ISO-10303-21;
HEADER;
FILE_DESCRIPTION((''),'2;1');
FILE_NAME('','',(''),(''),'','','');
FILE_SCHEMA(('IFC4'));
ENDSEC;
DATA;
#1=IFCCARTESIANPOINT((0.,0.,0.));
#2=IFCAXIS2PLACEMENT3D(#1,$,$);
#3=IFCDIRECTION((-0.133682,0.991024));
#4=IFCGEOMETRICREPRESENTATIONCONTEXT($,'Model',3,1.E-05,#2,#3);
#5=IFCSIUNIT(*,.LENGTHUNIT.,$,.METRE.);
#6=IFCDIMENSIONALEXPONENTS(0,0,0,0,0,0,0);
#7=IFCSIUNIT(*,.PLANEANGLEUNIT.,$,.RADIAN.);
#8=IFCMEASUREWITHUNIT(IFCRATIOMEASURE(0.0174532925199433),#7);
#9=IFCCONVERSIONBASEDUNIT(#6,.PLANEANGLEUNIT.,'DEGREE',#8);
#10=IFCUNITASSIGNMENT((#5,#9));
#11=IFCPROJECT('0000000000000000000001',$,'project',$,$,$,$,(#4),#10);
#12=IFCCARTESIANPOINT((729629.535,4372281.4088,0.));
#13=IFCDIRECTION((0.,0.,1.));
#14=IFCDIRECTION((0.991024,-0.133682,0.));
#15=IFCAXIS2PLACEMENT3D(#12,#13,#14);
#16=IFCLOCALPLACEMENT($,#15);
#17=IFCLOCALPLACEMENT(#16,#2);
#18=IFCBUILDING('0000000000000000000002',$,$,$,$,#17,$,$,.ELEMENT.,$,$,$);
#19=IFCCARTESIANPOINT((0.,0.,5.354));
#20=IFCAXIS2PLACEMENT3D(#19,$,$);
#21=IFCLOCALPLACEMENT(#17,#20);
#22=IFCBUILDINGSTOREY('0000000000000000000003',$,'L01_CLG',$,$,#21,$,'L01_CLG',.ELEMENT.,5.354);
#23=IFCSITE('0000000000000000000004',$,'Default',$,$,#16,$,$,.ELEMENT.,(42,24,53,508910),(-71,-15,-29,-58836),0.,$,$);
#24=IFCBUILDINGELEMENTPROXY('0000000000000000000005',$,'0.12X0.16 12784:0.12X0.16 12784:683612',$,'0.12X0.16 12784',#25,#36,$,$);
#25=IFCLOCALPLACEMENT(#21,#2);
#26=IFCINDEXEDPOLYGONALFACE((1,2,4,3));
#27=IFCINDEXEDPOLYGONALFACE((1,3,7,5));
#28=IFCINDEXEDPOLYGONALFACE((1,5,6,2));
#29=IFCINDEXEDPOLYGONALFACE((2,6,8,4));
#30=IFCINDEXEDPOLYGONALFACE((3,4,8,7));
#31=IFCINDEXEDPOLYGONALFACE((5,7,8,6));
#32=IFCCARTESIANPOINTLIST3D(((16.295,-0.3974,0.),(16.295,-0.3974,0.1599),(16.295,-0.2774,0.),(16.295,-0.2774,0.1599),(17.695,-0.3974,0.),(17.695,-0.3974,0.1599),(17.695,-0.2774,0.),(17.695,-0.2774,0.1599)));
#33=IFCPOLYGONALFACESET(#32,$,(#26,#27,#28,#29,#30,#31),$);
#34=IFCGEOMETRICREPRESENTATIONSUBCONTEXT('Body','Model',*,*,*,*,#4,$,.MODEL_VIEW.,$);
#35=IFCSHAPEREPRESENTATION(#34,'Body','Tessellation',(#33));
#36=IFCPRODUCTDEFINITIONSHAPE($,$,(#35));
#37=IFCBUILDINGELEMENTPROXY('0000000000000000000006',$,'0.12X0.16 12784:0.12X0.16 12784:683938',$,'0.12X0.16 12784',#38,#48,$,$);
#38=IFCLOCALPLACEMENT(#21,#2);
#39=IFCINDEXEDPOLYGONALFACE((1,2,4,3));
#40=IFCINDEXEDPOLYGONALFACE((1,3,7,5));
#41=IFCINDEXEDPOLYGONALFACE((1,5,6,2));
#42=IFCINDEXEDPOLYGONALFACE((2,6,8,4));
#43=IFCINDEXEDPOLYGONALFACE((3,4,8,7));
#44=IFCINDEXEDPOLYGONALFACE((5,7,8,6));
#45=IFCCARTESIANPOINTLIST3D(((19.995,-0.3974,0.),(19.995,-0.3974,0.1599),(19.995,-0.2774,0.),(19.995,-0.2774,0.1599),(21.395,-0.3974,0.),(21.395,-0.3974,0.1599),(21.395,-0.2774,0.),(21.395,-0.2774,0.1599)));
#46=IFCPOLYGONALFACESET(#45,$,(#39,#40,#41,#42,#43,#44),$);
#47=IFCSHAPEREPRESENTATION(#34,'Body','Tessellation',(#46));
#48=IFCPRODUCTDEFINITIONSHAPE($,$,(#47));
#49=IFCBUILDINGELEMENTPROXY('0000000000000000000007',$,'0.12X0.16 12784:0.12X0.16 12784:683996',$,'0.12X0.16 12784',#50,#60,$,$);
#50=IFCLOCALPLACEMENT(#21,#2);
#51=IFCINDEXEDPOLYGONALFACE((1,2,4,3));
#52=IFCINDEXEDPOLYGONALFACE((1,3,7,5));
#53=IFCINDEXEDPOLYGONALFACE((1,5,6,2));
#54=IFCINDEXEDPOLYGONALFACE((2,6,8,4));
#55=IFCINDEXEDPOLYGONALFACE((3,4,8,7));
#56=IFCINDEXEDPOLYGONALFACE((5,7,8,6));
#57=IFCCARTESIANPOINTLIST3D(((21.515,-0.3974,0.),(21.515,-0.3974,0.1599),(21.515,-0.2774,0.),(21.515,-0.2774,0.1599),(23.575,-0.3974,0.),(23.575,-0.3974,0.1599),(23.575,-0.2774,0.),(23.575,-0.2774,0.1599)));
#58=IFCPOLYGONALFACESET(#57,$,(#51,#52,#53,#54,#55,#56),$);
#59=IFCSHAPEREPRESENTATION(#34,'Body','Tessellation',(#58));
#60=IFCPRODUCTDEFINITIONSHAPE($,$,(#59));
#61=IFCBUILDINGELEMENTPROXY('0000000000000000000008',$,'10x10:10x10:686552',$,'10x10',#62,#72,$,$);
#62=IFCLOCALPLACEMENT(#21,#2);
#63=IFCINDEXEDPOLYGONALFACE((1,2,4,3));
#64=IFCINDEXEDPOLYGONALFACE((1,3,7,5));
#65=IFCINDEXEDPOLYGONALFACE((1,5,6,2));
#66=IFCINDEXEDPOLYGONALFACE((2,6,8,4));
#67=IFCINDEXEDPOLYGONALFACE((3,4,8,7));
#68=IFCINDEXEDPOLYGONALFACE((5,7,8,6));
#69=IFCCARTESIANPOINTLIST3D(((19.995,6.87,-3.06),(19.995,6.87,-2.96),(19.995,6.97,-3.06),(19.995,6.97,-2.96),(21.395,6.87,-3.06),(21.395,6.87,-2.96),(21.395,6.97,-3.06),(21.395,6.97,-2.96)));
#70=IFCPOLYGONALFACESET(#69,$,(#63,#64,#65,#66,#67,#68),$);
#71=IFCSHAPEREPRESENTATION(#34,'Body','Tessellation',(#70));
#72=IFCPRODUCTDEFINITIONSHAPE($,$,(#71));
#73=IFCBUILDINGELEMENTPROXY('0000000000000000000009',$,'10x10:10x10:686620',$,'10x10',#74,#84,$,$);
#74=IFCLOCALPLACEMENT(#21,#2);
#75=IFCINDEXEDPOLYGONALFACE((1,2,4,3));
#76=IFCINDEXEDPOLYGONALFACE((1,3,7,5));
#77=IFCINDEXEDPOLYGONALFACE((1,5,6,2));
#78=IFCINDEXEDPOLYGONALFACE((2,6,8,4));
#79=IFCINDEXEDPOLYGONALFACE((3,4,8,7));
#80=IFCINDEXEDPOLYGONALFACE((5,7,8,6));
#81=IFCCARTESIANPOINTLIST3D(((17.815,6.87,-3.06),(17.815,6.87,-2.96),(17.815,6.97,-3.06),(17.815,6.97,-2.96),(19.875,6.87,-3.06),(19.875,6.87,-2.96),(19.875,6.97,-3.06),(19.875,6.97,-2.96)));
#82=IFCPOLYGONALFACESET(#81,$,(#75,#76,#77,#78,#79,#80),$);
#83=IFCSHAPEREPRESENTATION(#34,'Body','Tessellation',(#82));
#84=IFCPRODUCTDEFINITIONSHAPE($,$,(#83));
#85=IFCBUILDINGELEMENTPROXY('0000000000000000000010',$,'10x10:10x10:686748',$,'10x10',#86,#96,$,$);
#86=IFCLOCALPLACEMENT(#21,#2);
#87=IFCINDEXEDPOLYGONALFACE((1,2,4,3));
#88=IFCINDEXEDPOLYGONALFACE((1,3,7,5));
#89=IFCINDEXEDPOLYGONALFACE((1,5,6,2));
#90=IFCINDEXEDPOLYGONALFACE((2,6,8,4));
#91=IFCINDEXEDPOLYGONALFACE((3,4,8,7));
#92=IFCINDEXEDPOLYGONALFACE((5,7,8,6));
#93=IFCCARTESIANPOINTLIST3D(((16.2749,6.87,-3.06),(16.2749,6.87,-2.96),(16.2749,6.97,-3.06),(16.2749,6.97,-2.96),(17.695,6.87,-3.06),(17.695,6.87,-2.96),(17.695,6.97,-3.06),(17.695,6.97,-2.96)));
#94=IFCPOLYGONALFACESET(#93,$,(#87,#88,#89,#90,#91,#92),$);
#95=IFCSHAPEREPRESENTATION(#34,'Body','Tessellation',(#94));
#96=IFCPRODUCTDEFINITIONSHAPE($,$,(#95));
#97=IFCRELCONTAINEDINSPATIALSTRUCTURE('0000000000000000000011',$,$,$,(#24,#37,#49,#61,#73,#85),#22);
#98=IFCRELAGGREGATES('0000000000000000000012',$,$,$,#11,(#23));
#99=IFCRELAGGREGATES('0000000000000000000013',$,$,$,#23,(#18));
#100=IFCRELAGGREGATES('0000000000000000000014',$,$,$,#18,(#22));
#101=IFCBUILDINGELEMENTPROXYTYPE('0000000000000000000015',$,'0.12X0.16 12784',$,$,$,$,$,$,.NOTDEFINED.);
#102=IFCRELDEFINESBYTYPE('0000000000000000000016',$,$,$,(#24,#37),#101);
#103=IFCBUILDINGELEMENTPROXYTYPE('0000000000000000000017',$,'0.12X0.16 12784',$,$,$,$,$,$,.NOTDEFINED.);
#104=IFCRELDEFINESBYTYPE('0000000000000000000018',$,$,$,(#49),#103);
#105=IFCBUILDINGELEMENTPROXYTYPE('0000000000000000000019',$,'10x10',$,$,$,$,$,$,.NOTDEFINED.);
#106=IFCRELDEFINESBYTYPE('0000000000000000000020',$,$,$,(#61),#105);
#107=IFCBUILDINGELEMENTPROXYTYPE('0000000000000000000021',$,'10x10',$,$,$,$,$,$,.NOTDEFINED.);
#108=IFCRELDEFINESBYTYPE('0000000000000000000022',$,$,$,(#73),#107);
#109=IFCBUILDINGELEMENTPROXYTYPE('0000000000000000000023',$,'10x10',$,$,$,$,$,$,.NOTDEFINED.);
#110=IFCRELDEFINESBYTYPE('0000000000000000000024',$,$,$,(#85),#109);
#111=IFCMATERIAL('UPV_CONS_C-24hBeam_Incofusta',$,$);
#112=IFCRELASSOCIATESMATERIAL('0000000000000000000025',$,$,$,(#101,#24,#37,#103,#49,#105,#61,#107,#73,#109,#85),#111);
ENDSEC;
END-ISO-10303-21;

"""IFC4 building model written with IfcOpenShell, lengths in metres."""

from ifc_helpers import new_model, entity, si_unit, converted_unit, direction, frame, frame_2d, origin, place, context, subcontext, project, spatial, rectangle, extrude, source, transform, mapped, material, type_object, type_shapes, element, save


model = new_model("IFC4")

# Units and contexts
model_context = context("Model", 3, precision=1e-05, world=origin(), true_north=direction((-0.133682, 0.991024)))
body_context = subcontext(model_context, "Body", "Model", "MODEL_VIEW")
ifc_project = project(units=[si_unit("LENGTHUNIT", "METRE"), converted_unit("PLANEANGLEUNIT", "DEGREE", entity("IfcRatioMeasure", 0.0174532925199433), si_unit("PLANEANGLEUNIT", "RADIAN"), dimensions=[0, 0, 0, 0, 0, 0, 0])], contexts=[model_context])

# Site, building, storey
site_placement = place(None, frame((729629.535, 4372281.4088, 0.0), z_axis=(0.0, 0.0, 1.0), x_axis=(0.991024, -0.133682, 0.0)))
site = spatial("IfcSite", under=ifc_project, at=site_placement, Name="Default", CompositionType="ELEMENT", RefLatitude=(42, 24, 53, 508910), RefLongitude=(-71, -15, -29, -58836), RefElevation=0.0)
building_placement = place(site_placement, origin())
building = spatial("IfcBuilding", under=site, at=building_placement, CompositionType="ELEMENT")
storey_placement = place(building_placement, frame((0.0, 0.0, 5.354)))
storey = spatial("IfcBuildingStorey", under=building, at=storey_placement, Name="L01_CLG", LongName="L01_CLG", CompositionType="ELEMENT", Elevation=5.354)

# Building element proxies
ifc_material_1 = material(Name="UPV_CONS_C-24hBeam_Incofusta")
building_element_proxy_type_1 = type_object("IfcBuildingElementProxyType", Name="0.12X0.16 12784", material=ifc_material_1)
shared_shape_1 = source(origin(), body_context, "Body", "SweptSolid", [
    extrude(rectangle(XDim=0.12, YDim=1.4, at=frame_2d((0.0, 0.0), x_axis=(1.0, 0.0))), frame((0.7, 0.06, 0.0), z_axis=(0.0, 0.0, 1.0), x_axis=(0.0, -1.0, 0.0)), (0.0, 0.0, 1.0), 0.1599),
])
type_shapes(building_element_proxy_type_1, [shared_shape_1])
for number, where, name in (
    (1, (16.295, -0.3974, 0.0), "0.12X0.16 12784:0.12X0.16 12784:683612"),
    (2, (19.995, -0.3974, 0.0), "0.12X0.16 12784:0.12X0.16 12784:683938"),
):
    element("IfcBuildingElementProxy", number, at=place(storey_placement, frame(where)), inside=storey, type_object=building_element_proxy_type_1, material=ifc_material_1, Name=name, ObjectType="0.12X0.16 12784", context=body_context, shape_type="MappedRepresentation", body=[
        mapped(shared_shape_1, transform((0.0, 0.0, 0.0), scale=1.0)),
    ])
building_element_proxy_type_2 = type_object("IfcBuildingElementProxyType", Name="0.12X0.16 12784", material=ifc_material_1)
shared_shape_2 = source(origin(), body_context, "Body", "SweptSolid", [
    extrude(rectangle(XDim=0.12, YDim=2.06, at=frame_2d((0.0, 0.0), x_axis=(1.0, 0.0))), frame((1.03, 0.06, 0.0), z_axis=(0.0, 0.0, 1.0), x_axis=(0.0, -1.0, 0.0)), (0.0, 0.0, 1.0), 0.1599),
])
type_shapes(building_element_proxy_type_2, [shared_shape_2])
proxy_1_placement = place(storey_placement, frame((21.515, -0.3974, 0.0)))
element("IfcBuildingElementProxy", 3, at=proxy_1_placement, inside=storey, type_object=building_element_proxy_type_2, material=ifc_material_1, Name="0.12X0.16 12784:0.12X0.16 12784:683996", ObjectType="0.12X0.16 12784", context=body_context, shape_type="MappedRepresentation", body=[
    mapped(shared_shape_2, transform((0.0, 0.0, 0.0), scale=1.0)),
])
building_element_proxy_type_3 = type_object("IfcBuildingElementProxyType", Name="10x10", material=ifc_material_1)
shared_shape_3 = source(origin(), body_context, "Body", "SweptSolid", [
    extrude(rectangle(XDim=0.1, YDim=1.4, at=frame_2d((0.0, 0.0), x_axis=(1.0, 0.0))), frame((0.7, 0.05, 0.0), z_axis=(0.0, 0.0, 1.0), x_axis=(0.0, -1.0, 0.0)), (0.0, 0.0, 1.0), 0.1),
])
type_shapes(building_element_proxy_type_3, [shared_shape_3])
proxy_2_placement = place(storey_placement, frame((19.995, 6.87, -3.06)))
element("IfcBuildingElementProxy", 4, at=proxy_2_placement, inside=storey, type_object=building_element_proxy_type_3, material=ifc_material_1, Name="10x10:10x10:686552", ObjectType="10x10", context=body_context, shape_type="MappedRepresentation", body=[
    mapped(shared_shape_3, transform((0.0, 0.0, 0.0), scale=1.0)),
])
building_element_proxy_type_4 = type_object("IfcBuildingElementProxyType", Name="10x10", material=ifc_material_1)
shared_shape_4 = source(origin(), body_context, "Body", "SweptSolid", [
    extrude(rectangle(XDim=0.1, YDim=2.06, at=frame_2d((0.0, 0.0), x_axis=(1.0, 0.0))), frame((1.03, 0.05, 0.0), z_axis=(0.0, 0.0, 1.0), x_axis=(0.0, -1.0, 0.0)), (0.0, 0.0, 1.0), 0.1),
])
type_shapes(building_element_proxy_type_4, [shared_shape_4])
proxy_3_placement = place(storey_placement, frame((17.815, 6.87, -3.06)))
element("IfcBuildingElementProxy", 5, at=proxy_3_placement, inside=storey, type_object=building_element_proxy_type_4, material=ifc_material_1, Name="10x10:10x10:686620", ObjectType="10x10", context=body_context, shape_type="MappedRepresentation", body=[
    mapped(shared_shape_4, transform((0.0, 0.0, 0.0), scale=1.0)),
])
building_element_proxy_type_5 = type_object("IfcBuildingElementProxyType", Name="10x10", material=ifc_material_1)
shared_shape_5 = source(origin(), body_context, "Body", "SweptSolid", [
    extrude(rectangle(XDim=0.1, YDim=1.4201, at=frame_2d((0.0, 0.0), x_axis=(1.0, 0.0))), frame((0.71, 0.05, 0.0), z_axis=(0.0, 0.0, 1.0), x_axis=(0.0, -1.0, 0.0)), (0.0, 0.0, 1.0), 0.1),
])
type_shapes(building_element_proxy_type_5, [shared_shape_5])
proxy_4_placement = place(storey_placement, frame((16.2749, 6.87, -3.06)))
element("IfcBuildingElementProxy", 6, at=proxy_4_placement, inside=storey, type_object=building_element_proxy_type_5, material=ifc_material_1, Name="10x10:10x10:686748", ObjectType="10x10", context=body_context, shape_type="MappedRepresentation", body=[
    mapped(shared_shape_5, transform((0.0, 0.0, 0.0), scale=1.0)),
])

save(model, "model.ifc")
